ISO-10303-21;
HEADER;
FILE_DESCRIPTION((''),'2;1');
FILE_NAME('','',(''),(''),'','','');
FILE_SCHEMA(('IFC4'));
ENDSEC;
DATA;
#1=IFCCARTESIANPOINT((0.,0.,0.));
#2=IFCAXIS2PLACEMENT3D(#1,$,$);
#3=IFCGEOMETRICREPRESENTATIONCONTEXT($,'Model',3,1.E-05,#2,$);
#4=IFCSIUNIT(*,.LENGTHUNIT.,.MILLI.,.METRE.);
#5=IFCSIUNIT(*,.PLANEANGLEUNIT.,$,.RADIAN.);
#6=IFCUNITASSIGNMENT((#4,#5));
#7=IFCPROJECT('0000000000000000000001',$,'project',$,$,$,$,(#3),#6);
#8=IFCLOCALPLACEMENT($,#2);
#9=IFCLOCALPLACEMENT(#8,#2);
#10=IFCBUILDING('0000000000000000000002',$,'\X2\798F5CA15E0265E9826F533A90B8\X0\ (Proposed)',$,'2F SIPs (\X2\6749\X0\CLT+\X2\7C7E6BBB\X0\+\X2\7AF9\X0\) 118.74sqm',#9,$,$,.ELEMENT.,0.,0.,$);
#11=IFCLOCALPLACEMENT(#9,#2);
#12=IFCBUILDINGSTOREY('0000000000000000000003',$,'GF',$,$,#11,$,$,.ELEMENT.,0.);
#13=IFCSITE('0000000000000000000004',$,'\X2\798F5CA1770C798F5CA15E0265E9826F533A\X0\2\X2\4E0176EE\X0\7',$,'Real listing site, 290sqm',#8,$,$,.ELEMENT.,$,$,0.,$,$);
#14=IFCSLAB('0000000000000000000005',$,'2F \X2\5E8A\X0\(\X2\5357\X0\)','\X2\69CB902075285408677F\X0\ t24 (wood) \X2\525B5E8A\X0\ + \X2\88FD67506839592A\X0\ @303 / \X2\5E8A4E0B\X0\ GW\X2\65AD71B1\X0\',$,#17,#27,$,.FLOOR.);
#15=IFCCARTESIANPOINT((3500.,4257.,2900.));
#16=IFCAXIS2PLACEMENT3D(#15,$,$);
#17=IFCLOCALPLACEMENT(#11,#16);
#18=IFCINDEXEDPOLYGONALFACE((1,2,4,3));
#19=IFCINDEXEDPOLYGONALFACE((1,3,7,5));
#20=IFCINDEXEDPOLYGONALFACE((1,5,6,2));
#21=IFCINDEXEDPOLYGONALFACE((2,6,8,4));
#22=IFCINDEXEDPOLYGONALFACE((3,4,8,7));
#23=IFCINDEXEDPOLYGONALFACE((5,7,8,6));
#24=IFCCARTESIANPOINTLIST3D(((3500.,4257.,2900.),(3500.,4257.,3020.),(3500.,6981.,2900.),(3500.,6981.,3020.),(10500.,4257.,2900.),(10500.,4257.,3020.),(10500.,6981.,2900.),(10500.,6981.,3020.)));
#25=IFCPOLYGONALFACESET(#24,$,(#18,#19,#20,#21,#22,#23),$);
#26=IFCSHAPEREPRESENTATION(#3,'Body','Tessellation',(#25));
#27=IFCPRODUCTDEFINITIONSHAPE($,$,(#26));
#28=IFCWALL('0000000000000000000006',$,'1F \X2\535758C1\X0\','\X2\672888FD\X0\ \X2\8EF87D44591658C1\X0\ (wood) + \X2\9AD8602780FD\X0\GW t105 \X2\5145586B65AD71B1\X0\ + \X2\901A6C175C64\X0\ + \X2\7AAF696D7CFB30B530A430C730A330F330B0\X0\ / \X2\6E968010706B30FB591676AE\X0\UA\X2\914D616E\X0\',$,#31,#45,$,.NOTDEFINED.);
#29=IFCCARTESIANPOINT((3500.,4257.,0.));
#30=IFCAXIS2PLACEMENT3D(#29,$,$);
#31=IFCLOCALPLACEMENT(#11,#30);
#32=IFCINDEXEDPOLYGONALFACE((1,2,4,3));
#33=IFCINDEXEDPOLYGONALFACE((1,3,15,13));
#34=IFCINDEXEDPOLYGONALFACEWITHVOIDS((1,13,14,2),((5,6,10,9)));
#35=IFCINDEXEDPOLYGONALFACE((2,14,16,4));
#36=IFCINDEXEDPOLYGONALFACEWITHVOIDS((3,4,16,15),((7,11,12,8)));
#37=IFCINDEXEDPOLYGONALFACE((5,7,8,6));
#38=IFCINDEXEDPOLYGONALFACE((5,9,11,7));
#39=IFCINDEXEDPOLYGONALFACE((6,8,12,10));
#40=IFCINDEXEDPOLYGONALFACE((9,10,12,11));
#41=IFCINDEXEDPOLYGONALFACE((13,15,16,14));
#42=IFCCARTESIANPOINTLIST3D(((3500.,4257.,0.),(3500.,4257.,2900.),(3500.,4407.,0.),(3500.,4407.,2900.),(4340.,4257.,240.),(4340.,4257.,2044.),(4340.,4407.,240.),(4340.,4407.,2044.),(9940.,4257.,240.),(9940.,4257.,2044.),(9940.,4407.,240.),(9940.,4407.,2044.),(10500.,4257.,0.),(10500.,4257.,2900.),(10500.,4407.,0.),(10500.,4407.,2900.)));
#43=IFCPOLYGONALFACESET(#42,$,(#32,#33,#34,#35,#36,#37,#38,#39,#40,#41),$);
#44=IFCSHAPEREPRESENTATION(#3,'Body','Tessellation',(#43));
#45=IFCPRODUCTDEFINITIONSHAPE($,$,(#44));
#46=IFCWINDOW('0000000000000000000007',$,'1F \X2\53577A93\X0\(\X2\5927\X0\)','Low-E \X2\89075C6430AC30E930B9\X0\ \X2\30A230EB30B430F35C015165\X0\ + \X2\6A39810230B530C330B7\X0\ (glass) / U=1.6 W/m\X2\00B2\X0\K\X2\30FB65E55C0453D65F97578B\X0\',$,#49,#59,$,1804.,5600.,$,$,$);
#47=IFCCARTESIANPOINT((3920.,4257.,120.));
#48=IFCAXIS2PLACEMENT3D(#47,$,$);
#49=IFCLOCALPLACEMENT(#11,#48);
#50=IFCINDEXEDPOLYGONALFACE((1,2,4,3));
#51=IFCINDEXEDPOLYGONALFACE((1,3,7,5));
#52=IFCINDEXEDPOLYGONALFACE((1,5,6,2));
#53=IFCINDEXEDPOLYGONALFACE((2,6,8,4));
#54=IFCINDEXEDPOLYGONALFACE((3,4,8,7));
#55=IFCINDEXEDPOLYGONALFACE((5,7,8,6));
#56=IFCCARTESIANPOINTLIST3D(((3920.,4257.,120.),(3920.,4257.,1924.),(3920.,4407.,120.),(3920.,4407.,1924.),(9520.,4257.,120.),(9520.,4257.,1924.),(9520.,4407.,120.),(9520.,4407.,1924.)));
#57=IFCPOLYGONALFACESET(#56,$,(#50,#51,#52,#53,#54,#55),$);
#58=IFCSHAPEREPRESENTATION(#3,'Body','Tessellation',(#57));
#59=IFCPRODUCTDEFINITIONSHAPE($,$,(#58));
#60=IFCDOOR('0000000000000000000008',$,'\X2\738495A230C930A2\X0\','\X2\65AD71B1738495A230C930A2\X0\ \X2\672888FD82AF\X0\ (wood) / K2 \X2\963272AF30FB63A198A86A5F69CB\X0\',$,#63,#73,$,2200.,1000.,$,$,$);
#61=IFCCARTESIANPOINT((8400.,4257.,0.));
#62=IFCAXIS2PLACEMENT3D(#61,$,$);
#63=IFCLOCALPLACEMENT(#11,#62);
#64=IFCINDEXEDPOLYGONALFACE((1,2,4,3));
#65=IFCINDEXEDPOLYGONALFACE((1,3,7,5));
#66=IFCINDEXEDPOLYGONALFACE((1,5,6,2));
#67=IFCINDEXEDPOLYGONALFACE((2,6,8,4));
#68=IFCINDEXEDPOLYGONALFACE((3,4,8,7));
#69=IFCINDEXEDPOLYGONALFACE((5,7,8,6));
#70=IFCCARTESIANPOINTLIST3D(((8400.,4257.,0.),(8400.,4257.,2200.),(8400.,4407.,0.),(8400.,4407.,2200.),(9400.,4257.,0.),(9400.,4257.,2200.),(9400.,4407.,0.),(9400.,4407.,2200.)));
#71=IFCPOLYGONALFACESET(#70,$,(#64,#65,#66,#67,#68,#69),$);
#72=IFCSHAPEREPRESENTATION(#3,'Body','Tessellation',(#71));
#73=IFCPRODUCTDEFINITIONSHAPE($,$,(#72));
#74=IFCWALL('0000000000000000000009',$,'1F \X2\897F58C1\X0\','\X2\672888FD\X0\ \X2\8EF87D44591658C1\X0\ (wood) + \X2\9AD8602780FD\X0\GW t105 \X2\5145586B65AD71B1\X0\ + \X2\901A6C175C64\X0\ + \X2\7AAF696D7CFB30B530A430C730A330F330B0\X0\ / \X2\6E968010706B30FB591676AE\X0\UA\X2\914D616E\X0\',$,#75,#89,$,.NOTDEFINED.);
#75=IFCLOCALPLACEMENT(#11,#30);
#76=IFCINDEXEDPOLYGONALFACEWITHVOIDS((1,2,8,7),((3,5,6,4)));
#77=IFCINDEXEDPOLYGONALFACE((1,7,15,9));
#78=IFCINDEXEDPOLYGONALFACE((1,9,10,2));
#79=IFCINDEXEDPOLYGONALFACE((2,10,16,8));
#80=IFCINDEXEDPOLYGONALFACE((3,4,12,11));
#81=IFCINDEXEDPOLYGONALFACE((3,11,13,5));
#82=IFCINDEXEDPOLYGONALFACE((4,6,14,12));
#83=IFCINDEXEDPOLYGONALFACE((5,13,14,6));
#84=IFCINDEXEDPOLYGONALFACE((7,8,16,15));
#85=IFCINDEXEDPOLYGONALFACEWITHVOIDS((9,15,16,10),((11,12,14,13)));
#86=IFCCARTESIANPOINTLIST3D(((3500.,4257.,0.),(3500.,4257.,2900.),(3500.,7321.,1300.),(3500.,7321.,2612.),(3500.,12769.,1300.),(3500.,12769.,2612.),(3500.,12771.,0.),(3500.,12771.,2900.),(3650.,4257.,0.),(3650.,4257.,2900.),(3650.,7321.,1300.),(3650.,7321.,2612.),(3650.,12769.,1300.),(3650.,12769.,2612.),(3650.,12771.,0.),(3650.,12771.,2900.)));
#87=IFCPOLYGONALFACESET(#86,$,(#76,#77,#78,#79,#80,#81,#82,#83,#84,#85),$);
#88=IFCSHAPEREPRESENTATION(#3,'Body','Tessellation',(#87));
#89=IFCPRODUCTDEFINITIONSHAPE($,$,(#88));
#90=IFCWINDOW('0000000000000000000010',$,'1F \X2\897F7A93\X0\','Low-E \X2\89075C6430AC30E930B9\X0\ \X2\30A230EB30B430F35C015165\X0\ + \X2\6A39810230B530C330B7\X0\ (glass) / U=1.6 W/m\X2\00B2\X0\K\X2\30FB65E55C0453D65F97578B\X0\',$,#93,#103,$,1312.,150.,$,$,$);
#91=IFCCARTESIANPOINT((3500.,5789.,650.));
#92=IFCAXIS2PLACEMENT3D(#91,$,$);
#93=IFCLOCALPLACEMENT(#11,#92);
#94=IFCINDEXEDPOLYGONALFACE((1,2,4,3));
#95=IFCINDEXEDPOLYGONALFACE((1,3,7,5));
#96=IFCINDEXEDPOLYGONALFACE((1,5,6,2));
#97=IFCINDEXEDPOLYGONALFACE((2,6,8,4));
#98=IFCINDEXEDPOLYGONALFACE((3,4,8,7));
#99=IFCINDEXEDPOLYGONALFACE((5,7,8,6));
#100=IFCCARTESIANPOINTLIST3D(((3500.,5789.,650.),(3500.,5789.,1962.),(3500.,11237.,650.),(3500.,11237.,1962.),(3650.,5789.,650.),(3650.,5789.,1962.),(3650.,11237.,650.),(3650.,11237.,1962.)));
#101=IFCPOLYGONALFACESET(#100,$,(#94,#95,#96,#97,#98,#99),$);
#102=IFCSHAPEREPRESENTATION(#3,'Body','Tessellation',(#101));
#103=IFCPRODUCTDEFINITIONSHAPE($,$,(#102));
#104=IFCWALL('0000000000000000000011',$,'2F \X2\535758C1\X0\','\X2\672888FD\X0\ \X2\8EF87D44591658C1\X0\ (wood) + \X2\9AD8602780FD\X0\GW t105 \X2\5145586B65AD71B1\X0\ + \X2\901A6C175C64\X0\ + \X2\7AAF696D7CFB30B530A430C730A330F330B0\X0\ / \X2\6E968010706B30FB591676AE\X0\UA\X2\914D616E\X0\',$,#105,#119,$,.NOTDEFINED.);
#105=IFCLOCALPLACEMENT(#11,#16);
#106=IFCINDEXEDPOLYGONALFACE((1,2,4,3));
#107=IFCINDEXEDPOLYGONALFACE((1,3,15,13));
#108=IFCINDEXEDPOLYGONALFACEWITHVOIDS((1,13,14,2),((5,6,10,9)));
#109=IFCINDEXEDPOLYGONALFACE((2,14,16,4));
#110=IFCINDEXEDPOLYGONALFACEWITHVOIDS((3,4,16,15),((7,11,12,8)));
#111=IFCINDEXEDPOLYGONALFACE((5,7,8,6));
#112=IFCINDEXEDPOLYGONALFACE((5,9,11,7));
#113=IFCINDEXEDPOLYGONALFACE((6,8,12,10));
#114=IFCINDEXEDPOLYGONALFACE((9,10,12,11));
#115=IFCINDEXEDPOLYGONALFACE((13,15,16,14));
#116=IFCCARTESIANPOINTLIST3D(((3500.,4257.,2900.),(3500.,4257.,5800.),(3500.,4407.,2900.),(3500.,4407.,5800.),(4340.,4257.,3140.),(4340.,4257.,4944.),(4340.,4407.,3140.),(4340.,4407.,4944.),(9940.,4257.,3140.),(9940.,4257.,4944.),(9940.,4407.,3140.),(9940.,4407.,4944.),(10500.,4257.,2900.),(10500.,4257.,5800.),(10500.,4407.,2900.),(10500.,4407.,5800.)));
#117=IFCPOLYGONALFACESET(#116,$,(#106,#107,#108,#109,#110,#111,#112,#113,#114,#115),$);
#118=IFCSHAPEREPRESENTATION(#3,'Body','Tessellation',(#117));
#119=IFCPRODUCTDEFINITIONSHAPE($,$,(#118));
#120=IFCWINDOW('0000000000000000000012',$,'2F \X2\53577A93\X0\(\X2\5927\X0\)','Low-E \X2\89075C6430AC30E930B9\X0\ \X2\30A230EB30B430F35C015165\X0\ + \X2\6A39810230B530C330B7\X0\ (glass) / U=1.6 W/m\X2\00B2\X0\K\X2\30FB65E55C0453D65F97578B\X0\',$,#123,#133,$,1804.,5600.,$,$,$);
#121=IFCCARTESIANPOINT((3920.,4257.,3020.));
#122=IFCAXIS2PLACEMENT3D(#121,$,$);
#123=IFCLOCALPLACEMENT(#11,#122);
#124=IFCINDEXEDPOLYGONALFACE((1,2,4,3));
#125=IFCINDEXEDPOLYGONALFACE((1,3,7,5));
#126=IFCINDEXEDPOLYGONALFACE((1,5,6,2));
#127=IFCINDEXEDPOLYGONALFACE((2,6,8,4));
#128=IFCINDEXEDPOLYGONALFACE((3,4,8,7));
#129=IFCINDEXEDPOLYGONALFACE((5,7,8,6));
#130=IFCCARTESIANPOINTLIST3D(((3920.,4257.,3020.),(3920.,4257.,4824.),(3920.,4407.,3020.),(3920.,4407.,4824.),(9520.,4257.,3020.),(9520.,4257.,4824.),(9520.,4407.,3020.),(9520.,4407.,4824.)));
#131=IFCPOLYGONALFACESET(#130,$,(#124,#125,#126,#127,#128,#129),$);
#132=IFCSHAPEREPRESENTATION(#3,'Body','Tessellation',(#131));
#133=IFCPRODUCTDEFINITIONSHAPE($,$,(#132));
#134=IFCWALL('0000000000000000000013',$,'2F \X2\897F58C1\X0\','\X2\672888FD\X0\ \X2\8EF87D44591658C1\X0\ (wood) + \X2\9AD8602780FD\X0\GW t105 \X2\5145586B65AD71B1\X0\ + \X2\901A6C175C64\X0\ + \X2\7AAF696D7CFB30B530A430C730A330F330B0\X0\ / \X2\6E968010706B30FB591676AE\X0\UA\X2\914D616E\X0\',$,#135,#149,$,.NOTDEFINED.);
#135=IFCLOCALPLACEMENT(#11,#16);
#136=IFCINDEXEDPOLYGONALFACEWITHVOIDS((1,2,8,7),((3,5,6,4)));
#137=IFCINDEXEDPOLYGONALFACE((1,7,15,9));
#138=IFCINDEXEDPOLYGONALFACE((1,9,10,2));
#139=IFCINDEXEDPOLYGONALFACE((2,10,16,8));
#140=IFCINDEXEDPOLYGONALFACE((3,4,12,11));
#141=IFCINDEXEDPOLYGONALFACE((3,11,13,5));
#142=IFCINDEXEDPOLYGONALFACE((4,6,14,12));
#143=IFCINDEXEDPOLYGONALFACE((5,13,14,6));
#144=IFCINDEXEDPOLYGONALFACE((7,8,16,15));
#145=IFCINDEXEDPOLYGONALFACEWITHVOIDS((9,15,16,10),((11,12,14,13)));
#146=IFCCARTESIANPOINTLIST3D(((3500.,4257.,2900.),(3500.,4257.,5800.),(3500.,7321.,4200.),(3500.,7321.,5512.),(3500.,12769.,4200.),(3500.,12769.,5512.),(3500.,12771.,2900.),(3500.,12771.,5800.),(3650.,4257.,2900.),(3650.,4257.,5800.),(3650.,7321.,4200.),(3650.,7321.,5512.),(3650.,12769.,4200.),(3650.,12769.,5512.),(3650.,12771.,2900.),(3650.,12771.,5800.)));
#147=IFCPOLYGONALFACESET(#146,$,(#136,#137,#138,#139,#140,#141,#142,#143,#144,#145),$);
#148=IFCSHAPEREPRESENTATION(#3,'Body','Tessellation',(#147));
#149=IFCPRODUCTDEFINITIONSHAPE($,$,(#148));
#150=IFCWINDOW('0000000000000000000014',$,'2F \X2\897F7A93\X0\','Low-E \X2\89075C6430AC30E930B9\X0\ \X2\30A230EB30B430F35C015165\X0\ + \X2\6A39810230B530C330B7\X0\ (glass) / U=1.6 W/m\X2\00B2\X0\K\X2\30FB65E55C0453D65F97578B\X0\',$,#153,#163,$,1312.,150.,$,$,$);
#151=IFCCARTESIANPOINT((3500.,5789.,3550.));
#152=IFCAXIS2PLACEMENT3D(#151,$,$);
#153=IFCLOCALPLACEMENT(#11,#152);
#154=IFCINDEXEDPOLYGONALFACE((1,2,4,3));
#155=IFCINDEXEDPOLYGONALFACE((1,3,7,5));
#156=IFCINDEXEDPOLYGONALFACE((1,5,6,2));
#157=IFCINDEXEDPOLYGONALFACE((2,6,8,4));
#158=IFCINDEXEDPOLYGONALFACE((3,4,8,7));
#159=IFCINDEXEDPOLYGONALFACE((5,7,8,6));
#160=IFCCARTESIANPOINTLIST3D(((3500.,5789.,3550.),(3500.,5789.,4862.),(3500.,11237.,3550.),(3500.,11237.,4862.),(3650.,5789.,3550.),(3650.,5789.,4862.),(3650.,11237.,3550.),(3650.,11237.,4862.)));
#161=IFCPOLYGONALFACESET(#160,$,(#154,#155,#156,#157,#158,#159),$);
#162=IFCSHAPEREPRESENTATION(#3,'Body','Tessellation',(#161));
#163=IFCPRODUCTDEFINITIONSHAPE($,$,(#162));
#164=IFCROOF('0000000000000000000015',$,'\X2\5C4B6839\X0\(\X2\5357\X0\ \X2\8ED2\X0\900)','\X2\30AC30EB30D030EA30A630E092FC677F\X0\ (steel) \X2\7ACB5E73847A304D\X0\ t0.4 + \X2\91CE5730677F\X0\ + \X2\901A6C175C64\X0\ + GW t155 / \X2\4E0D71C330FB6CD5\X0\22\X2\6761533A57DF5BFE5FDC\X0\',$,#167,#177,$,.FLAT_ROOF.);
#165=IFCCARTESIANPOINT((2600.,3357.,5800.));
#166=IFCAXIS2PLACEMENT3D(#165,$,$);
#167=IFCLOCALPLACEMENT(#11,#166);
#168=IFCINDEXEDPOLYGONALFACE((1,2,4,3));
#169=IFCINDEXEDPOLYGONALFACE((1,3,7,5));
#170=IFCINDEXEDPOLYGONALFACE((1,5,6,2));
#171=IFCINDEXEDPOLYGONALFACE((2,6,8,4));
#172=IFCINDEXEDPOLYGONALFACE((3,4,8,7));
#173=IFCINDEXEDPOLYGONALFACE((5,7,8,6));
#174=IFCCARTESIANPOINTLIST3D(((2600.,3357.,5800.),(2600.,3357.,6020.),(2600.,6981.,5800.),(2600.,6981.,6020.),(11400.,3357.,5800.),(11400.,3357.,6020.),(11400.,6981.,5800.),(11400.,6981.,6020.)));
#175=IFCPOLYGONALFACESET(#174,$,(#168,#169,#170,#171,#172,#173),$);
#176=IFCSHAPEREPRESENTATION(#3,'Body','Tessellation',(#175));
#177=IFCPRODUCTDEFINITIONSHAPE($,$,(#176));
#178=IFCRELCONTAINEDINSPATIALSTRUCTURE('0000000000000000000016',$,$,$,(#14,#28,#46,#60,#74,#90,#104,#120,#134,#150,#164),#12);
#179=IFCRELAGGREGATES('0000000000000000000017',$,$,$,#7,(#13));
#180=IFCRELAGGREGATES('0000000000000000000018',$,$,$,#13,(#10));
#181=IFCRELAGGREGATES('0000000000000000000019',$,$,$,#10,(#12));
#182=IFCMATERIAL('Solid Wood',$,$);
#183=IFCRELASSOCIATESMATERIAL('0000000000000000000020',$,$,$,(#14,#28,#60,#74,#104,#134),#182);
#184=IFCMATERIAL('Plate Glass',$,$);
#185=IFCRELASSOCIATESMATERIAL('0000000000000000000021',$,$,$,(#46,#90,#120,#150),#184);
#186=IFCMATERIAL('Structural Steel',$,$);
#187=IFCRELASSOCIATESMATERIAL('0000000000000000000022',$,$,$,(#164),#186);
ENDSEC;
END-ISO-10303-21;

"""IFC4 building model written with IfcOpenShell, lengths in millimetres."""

from ifc_helpers import new_model, si_unit, frame, frame_2d, origin, place, context, project, spatial, rectangle, extrude, material, element, fill, save


model = new_model("IFC4")

# Units and contexts
model_context = context("Model", 3, precision=1e-05, world=origin())
ifc_project = project(units=[si_unit("LENGTHUNIT", "METRE", prefix="MILLI"), si_unit("PLANEANGLEUNIT", "RADIAN")], contexts=[model_context])

# Site, building, storey
site_placement = place(None, origin())
site = spatial("IfcSite", under=ifc_project, at=site_placement, Name="福岡県福岡市早良区2丁目7", ObjectType="Real listing site, 290sqm", CompositionType="ELEMENT", RefElevation=0.0)
building_placement = place(site_placement, origin())
building = spatial("IfcBuilding", under=site, at=building_placement, Name="福岡市早良区邸 (Proposed)", ObjectType="2F SIPs (杉CLT+籾殻+竹) 118.74sqm", CompositionType="ELEMENT", ElevationOfRefHeight=0.0, ElevationOfTerrain=0.0)
storey_placement = place(building_placement, origin())
storey = spatial("IfcBuildingStorey", under=building, at=storey_placement, Name="GF", CompositionType="ELEMENT", Elevation=0.0)

# Slab
ifc_material_1 = material(Name="Solid Wood")
slab_1_placement = place(storey_placement, frame((3500.0, 4257.0, 2900.0)))
element("IfcSlab", 1, at=slab_1_placement, inside=storey, material=ifc_material_1, Name="2F 床(南)", Description="構造用合板 t24 (wood) 剛床 + 製材根太 @303 / 床下 GW断熱", PredefinedType="FLOOR", context=model_context, shape_type="SweptSolid", body=[
    extrude(rectangle(XDim=7000.0, YDim=2724.0, at=frame_2d((3500.0, 1362.0))), frame((3500.0, 4257.0, 2900.0)), (0.0, 0.0, 1.0), 120.0),
])

# Wall, openings, window, door
wall_1_placement = place(storey_placement, frame((3500.0, 4257.0, 0.0)))
wall_1 = element("IfcWall", 2, at=wall_1_placement, inside=storey, material=ifc_material_1, Name="1F 南壁", Description="木製 軸組外壁 (wood) + 高性能GW t105 充填断熱 + 通気層 + 窯業系サイディング / 準耐火・外皮UA配慮", PredefinedType="NOTDEFINED", context=model_context, shape_type="SweptSolid", body=[
    extrude(rectangle(XDim=7000.0, YDim=150.0, at=frame_2d((3500.0, 75.0))), frame((3500.0, 4257.0, 0.0)), (0.0, 0.0, 1.0), 2900.0),
])
opening_1_placement = place(storey_placement, frame((3920.0, 4257.0, 120.0)))
opening_1 = element("IfcOpeningElement", 3, at=opening_1_placement, cuts=wall_1, PredefinedType="NOTDEFINED", context=model_context, shape_type="SweptSolid", body=[
    extrude(rectangle(XDim=5600.0, YDim=150.0, at=frame_2d((2800.0, 75.0))), frame((3920.0, 4257.0, 120.0)), (0.0, 0.0, 1.0), 1804.0),
])
opening_2_placement = place(storey_placement, frame((8400.0, 4257.0, 0.0)))
opening_2 = element("IfcOpeningElement", 4, at=opening_2_placement, cuts=wall_1, PredefinedType="NOTDEFINED", context=model_context, shape_type="SweptSolid", body=[
    extrude(rectangle(XDim=1000.0, YDim=150.0, at=frame_2d((500.0, 75.0))), frame((8400.0, 4257.0, 0.0)), (0.0, 0.0, 1.0), 2200.0),
])
ifc_material_2 = material(Name="Plate Glass")
window_1_placement = place(storey_placement, frame((3920.0, 4257.0, 120.0)))
window_1 = element("IfcWindow", 5, at=window_1_placement, inside=storey, material=ifc_material_2, Name="1F 南窓(大)", Description="Low-E 複層ガラス アルゴン封入 + 樹脂サッシ (glass) / U=1.6 W/m²K・日射取得型", OverallHeight=1804.0, OverallWidth=5600.0, context=model_context, shape_type="SweptSolid", body=[
    extrude(rectangle(XDim=5600.0, YDim=150.0, at=frame_2d((2800.0, 75.0))), frame((3920.0, 4257.0, 120.0)), (0.0, 0.0, 1.0), 1804.0),
])
fill(opening_1, window_1)
door_placement = place(storey_placement, frame((8400.0, 4257.0, 0.0)))
door = element("IfcDoor", 6, at=door_placement, inside=storey, material=ifc_material_1, Name="玄関ドア", Description="断熱玄関ドア 木製芯 (wood) / K2 防犯・採風機構", OverallHeight=2200.0, OverallWidth=1000.0, context=model_context, shape_type="SweptSolid", body=[
    extrude(rectangle(XDim=1000.0, YDim=150.0, at=frame_2d((500.0, 75.0))), frame((8400.0, 4257.0, 0.0)), (0.0, 0.0, 1.0), 2200.0),
])
fill(opening_2, door)

# Walls, openings, windows
wall_2_placement = place(storey_placement, frame((3500.0, 4257.0, 0.0)))
wall_2 = element("IfcWall", 7, at=wall_2_placement, inside=storey, material=ifc_material_1, Name="1F 西壁", Description="木製 軸組外壁 (wood) + 高性能GW t105 充填断熱 + 通気層 + 窯業系サイディング / 準耐火・外皮UA配慮", PredefinedType="NOTDEFINED", context=model_context, shape_type="SweptSolid", body=[
    extrude(rectangle(XDim=150.0, YDim=8514.0, at=frame_2d((75.0, 4257.0))), frame((3500.0, 4257.0, 0.0)), (0.0, 0.0, 1.0), 2900.0),
])
opening_3_placement = place(storey_placement, frame((3500.0, 5789.0, 650.0)))
opening_3 = element("IfcOpeningElement", 8, at=opening_3_placement, cuts=wall_2, PredefinedType="NOTDEFINED", context=model_context, shape_type="SweptSolid", body=[
    extrude(rectangle(XDim=150.0, YDim=5448.0, at=frame_2d((75.0, 2724.0))), frame((3500.0, 5789.0, 650.0)), (0.0, 0.0, 1.0), 1312.0),
])
window_2_placement = place(storey_placement, frame((3500.0, 5789.0, 650.0)))
window_2 = element("IfcWindow", 9, at=window_2_placement, inside=storey, material=ifc_material_2, Name="1F 西窓", Description="Low-E 複層ガラス アルゴン封入 + 樹脂サッシ (glass) / U=1.6 W/m²K・日射取得型", OverallHeight=1312.0, OverallWidth=150.0, context=model_context, shape_type="SweptSolid", body=[
    extrude(rectangle(XDim=150.0, YDim=5448.0, at=frame_2d((75.0, 2724.0))), frame((3500.0, 5789.0, 650.0)), (0.0, 0.0, 1.0), 1312.0),
])
fill(opening_3, window_2)
wall_3_placement = place(storey_placement, frame((3500.0, 4257.0, 2900.0)))
wall_3 = element("IfcWall", 10, at=wall_3_placement, inside=storey, material=ifc_material_1, Name="2F 南壁", Description="木製 軸組外壁 (wood) + 高性能GW t105 充填断熱 + 通気層 + 窯業系サイディング / 準耐火・外皮UA配慮", PredefinedType="NOTDEFINED", context=model_context, shape_type="SweptSolid", body=[
    extrude(rectangle(XDim=7000.0, YDim=150.0, at=frame_2d((3500.0, 75.0))), frame((3500.0, 4257.0, 2900.0)), (0.0, 0.0, 1.0), 2900.0),
])
opening_4_placement = place(storey_placement, frame((3920.0, 4257.0, 3020.0)))
opening_4 = element("IfcOpeningElement", 11, at=opening_4_placement, cuts=wall_3, PredefinedType="NOTDEFINED", context=model_context, shape_type="SweptSolid", body=[
    extrude(rectangle(XDim=5600.0, YDim=150.0, at=frame_2d((2800.0, 75.0))), frame((3920.0, 4257.0, 3020.0)), (0.0, 0.0, 1.0), 1804.0),
])
window_3_placement = place(storey_placement, frame((3920.0, 4257.0, 3020.0)))
window_3 = element("IfcWindow", 12, at=window_3_placement, inside=storey, material=ifc_material_2, Name="2F 南窓(大)", Description="Low-E 複層ガラス アルゴン封入 + 樹脂サッシ (glass) / U=1.6 W/m²K・日射取得型", OverallHeight=1804.0, OverallWidth=5600.0, context=model_context, shape_type="SweptSolid", body=[
    extrude(rectangle(XDim=5600.0, YDim=150.0, at=frame_2d((2800.0, 75.0))), frame((3920.0, 4257.0, 3020.0)), (0.0, 0.0, 1.0), 1804.0),
])
fill(opening_4, window_3)
wall_4_placement = place(storey_placement, frame((3500.0, 4257.0, 2900.0)))
wall_4 = element("IfcWall", 13, at=wall_4_placement, inside=storey, material=ifc_material_1, Name="2F 西壁", Description="木製 軸組外壁 (wood) + 高性能GW t105 充填断熱 + 通気層 + 窯業系サイディング / 準耐火・外皮UA配慮", PredefinedType="NOTDEFINED", context=model_context, shape_type="SweptSolid", body=[
    extrude(rectangle(XDim=150.0, YDim=8514.0, at=frame_2d((75.0, 4257.0))), frame((3500.0, 4257.0, 2900.0)), (0.0, 0.0, 1.0), 2900.0),
])
opening_5_placement = place(storey_placement, frame((3500.0, 5789.0, 3550.0)))
opening_5 = element("IfcOpeningElement", 14, at=opening_5_placement, cuts=wall_4, PredefinedType="NOTDEFINED", context=model_context, shape_type="SweptSolid", body=[
    extrude(rectangle(XDim=150.0, YDim=5448.0, at=frame_2d((75.0, 2724.0))), frame((3500.0, 5789.0, 3550.0)), (0.0, 0.0, 1.0), 1312.0),
])
window_4_placement = place(storey_placement, frame((3500.0, 5789.0, 3550.0)))
window_4 = element("IfcWindow", 15, at=window_4_placement, inside=storey, material=ifc_material_2, Name="2F 西窓", Description="Low-E 複層ガラス アルゴン封入 + 樹脂サッシ (glass) / U=1.6 W/m²K・日射取得型", OverallHeight=1312.0, OverallWidth=150.0, context=model_context, shape_type="SweptSolid", body=[
    extrude(rectangle(XDim=150.0, YDim=5448.0, at=frame_2d((75.0, 2724.0))), frame((3500.0, 5789.0, 3550.0)), (0.0, 0.0, 1.0), 1312.0),
])
fill(opening_5, window_4)

# Roof
ifc_material_3 = material(Name="Structural Steel")
roof_1_placement = place(storey_placement, frame((2600.0, 3357.0, 5800.0)))
element("IfcRoof", 16, at=roof_1_placement, inside=storey, material=ifc_material_3, Name="屋根(南 軒900)", Description="ガルバリウム鋼板 (steel) 立平葺き t0.4 + 野地板 + 通気層 + GW t155 / 不燃・法22条区域対応", PredefinedType="FLAT_ROOF", context=model_context, shape_type="SweptSolid", body=[
    extrude(rectangle(XDim=8800.0, YDim=3624.0, at=frame_2d((4400.0, 1812.0))), frame((2600.0, 3357.0, 5800.0)), (0.0, 0.0, 1.0), 220.0),
])

save(model, "model.ifc")
